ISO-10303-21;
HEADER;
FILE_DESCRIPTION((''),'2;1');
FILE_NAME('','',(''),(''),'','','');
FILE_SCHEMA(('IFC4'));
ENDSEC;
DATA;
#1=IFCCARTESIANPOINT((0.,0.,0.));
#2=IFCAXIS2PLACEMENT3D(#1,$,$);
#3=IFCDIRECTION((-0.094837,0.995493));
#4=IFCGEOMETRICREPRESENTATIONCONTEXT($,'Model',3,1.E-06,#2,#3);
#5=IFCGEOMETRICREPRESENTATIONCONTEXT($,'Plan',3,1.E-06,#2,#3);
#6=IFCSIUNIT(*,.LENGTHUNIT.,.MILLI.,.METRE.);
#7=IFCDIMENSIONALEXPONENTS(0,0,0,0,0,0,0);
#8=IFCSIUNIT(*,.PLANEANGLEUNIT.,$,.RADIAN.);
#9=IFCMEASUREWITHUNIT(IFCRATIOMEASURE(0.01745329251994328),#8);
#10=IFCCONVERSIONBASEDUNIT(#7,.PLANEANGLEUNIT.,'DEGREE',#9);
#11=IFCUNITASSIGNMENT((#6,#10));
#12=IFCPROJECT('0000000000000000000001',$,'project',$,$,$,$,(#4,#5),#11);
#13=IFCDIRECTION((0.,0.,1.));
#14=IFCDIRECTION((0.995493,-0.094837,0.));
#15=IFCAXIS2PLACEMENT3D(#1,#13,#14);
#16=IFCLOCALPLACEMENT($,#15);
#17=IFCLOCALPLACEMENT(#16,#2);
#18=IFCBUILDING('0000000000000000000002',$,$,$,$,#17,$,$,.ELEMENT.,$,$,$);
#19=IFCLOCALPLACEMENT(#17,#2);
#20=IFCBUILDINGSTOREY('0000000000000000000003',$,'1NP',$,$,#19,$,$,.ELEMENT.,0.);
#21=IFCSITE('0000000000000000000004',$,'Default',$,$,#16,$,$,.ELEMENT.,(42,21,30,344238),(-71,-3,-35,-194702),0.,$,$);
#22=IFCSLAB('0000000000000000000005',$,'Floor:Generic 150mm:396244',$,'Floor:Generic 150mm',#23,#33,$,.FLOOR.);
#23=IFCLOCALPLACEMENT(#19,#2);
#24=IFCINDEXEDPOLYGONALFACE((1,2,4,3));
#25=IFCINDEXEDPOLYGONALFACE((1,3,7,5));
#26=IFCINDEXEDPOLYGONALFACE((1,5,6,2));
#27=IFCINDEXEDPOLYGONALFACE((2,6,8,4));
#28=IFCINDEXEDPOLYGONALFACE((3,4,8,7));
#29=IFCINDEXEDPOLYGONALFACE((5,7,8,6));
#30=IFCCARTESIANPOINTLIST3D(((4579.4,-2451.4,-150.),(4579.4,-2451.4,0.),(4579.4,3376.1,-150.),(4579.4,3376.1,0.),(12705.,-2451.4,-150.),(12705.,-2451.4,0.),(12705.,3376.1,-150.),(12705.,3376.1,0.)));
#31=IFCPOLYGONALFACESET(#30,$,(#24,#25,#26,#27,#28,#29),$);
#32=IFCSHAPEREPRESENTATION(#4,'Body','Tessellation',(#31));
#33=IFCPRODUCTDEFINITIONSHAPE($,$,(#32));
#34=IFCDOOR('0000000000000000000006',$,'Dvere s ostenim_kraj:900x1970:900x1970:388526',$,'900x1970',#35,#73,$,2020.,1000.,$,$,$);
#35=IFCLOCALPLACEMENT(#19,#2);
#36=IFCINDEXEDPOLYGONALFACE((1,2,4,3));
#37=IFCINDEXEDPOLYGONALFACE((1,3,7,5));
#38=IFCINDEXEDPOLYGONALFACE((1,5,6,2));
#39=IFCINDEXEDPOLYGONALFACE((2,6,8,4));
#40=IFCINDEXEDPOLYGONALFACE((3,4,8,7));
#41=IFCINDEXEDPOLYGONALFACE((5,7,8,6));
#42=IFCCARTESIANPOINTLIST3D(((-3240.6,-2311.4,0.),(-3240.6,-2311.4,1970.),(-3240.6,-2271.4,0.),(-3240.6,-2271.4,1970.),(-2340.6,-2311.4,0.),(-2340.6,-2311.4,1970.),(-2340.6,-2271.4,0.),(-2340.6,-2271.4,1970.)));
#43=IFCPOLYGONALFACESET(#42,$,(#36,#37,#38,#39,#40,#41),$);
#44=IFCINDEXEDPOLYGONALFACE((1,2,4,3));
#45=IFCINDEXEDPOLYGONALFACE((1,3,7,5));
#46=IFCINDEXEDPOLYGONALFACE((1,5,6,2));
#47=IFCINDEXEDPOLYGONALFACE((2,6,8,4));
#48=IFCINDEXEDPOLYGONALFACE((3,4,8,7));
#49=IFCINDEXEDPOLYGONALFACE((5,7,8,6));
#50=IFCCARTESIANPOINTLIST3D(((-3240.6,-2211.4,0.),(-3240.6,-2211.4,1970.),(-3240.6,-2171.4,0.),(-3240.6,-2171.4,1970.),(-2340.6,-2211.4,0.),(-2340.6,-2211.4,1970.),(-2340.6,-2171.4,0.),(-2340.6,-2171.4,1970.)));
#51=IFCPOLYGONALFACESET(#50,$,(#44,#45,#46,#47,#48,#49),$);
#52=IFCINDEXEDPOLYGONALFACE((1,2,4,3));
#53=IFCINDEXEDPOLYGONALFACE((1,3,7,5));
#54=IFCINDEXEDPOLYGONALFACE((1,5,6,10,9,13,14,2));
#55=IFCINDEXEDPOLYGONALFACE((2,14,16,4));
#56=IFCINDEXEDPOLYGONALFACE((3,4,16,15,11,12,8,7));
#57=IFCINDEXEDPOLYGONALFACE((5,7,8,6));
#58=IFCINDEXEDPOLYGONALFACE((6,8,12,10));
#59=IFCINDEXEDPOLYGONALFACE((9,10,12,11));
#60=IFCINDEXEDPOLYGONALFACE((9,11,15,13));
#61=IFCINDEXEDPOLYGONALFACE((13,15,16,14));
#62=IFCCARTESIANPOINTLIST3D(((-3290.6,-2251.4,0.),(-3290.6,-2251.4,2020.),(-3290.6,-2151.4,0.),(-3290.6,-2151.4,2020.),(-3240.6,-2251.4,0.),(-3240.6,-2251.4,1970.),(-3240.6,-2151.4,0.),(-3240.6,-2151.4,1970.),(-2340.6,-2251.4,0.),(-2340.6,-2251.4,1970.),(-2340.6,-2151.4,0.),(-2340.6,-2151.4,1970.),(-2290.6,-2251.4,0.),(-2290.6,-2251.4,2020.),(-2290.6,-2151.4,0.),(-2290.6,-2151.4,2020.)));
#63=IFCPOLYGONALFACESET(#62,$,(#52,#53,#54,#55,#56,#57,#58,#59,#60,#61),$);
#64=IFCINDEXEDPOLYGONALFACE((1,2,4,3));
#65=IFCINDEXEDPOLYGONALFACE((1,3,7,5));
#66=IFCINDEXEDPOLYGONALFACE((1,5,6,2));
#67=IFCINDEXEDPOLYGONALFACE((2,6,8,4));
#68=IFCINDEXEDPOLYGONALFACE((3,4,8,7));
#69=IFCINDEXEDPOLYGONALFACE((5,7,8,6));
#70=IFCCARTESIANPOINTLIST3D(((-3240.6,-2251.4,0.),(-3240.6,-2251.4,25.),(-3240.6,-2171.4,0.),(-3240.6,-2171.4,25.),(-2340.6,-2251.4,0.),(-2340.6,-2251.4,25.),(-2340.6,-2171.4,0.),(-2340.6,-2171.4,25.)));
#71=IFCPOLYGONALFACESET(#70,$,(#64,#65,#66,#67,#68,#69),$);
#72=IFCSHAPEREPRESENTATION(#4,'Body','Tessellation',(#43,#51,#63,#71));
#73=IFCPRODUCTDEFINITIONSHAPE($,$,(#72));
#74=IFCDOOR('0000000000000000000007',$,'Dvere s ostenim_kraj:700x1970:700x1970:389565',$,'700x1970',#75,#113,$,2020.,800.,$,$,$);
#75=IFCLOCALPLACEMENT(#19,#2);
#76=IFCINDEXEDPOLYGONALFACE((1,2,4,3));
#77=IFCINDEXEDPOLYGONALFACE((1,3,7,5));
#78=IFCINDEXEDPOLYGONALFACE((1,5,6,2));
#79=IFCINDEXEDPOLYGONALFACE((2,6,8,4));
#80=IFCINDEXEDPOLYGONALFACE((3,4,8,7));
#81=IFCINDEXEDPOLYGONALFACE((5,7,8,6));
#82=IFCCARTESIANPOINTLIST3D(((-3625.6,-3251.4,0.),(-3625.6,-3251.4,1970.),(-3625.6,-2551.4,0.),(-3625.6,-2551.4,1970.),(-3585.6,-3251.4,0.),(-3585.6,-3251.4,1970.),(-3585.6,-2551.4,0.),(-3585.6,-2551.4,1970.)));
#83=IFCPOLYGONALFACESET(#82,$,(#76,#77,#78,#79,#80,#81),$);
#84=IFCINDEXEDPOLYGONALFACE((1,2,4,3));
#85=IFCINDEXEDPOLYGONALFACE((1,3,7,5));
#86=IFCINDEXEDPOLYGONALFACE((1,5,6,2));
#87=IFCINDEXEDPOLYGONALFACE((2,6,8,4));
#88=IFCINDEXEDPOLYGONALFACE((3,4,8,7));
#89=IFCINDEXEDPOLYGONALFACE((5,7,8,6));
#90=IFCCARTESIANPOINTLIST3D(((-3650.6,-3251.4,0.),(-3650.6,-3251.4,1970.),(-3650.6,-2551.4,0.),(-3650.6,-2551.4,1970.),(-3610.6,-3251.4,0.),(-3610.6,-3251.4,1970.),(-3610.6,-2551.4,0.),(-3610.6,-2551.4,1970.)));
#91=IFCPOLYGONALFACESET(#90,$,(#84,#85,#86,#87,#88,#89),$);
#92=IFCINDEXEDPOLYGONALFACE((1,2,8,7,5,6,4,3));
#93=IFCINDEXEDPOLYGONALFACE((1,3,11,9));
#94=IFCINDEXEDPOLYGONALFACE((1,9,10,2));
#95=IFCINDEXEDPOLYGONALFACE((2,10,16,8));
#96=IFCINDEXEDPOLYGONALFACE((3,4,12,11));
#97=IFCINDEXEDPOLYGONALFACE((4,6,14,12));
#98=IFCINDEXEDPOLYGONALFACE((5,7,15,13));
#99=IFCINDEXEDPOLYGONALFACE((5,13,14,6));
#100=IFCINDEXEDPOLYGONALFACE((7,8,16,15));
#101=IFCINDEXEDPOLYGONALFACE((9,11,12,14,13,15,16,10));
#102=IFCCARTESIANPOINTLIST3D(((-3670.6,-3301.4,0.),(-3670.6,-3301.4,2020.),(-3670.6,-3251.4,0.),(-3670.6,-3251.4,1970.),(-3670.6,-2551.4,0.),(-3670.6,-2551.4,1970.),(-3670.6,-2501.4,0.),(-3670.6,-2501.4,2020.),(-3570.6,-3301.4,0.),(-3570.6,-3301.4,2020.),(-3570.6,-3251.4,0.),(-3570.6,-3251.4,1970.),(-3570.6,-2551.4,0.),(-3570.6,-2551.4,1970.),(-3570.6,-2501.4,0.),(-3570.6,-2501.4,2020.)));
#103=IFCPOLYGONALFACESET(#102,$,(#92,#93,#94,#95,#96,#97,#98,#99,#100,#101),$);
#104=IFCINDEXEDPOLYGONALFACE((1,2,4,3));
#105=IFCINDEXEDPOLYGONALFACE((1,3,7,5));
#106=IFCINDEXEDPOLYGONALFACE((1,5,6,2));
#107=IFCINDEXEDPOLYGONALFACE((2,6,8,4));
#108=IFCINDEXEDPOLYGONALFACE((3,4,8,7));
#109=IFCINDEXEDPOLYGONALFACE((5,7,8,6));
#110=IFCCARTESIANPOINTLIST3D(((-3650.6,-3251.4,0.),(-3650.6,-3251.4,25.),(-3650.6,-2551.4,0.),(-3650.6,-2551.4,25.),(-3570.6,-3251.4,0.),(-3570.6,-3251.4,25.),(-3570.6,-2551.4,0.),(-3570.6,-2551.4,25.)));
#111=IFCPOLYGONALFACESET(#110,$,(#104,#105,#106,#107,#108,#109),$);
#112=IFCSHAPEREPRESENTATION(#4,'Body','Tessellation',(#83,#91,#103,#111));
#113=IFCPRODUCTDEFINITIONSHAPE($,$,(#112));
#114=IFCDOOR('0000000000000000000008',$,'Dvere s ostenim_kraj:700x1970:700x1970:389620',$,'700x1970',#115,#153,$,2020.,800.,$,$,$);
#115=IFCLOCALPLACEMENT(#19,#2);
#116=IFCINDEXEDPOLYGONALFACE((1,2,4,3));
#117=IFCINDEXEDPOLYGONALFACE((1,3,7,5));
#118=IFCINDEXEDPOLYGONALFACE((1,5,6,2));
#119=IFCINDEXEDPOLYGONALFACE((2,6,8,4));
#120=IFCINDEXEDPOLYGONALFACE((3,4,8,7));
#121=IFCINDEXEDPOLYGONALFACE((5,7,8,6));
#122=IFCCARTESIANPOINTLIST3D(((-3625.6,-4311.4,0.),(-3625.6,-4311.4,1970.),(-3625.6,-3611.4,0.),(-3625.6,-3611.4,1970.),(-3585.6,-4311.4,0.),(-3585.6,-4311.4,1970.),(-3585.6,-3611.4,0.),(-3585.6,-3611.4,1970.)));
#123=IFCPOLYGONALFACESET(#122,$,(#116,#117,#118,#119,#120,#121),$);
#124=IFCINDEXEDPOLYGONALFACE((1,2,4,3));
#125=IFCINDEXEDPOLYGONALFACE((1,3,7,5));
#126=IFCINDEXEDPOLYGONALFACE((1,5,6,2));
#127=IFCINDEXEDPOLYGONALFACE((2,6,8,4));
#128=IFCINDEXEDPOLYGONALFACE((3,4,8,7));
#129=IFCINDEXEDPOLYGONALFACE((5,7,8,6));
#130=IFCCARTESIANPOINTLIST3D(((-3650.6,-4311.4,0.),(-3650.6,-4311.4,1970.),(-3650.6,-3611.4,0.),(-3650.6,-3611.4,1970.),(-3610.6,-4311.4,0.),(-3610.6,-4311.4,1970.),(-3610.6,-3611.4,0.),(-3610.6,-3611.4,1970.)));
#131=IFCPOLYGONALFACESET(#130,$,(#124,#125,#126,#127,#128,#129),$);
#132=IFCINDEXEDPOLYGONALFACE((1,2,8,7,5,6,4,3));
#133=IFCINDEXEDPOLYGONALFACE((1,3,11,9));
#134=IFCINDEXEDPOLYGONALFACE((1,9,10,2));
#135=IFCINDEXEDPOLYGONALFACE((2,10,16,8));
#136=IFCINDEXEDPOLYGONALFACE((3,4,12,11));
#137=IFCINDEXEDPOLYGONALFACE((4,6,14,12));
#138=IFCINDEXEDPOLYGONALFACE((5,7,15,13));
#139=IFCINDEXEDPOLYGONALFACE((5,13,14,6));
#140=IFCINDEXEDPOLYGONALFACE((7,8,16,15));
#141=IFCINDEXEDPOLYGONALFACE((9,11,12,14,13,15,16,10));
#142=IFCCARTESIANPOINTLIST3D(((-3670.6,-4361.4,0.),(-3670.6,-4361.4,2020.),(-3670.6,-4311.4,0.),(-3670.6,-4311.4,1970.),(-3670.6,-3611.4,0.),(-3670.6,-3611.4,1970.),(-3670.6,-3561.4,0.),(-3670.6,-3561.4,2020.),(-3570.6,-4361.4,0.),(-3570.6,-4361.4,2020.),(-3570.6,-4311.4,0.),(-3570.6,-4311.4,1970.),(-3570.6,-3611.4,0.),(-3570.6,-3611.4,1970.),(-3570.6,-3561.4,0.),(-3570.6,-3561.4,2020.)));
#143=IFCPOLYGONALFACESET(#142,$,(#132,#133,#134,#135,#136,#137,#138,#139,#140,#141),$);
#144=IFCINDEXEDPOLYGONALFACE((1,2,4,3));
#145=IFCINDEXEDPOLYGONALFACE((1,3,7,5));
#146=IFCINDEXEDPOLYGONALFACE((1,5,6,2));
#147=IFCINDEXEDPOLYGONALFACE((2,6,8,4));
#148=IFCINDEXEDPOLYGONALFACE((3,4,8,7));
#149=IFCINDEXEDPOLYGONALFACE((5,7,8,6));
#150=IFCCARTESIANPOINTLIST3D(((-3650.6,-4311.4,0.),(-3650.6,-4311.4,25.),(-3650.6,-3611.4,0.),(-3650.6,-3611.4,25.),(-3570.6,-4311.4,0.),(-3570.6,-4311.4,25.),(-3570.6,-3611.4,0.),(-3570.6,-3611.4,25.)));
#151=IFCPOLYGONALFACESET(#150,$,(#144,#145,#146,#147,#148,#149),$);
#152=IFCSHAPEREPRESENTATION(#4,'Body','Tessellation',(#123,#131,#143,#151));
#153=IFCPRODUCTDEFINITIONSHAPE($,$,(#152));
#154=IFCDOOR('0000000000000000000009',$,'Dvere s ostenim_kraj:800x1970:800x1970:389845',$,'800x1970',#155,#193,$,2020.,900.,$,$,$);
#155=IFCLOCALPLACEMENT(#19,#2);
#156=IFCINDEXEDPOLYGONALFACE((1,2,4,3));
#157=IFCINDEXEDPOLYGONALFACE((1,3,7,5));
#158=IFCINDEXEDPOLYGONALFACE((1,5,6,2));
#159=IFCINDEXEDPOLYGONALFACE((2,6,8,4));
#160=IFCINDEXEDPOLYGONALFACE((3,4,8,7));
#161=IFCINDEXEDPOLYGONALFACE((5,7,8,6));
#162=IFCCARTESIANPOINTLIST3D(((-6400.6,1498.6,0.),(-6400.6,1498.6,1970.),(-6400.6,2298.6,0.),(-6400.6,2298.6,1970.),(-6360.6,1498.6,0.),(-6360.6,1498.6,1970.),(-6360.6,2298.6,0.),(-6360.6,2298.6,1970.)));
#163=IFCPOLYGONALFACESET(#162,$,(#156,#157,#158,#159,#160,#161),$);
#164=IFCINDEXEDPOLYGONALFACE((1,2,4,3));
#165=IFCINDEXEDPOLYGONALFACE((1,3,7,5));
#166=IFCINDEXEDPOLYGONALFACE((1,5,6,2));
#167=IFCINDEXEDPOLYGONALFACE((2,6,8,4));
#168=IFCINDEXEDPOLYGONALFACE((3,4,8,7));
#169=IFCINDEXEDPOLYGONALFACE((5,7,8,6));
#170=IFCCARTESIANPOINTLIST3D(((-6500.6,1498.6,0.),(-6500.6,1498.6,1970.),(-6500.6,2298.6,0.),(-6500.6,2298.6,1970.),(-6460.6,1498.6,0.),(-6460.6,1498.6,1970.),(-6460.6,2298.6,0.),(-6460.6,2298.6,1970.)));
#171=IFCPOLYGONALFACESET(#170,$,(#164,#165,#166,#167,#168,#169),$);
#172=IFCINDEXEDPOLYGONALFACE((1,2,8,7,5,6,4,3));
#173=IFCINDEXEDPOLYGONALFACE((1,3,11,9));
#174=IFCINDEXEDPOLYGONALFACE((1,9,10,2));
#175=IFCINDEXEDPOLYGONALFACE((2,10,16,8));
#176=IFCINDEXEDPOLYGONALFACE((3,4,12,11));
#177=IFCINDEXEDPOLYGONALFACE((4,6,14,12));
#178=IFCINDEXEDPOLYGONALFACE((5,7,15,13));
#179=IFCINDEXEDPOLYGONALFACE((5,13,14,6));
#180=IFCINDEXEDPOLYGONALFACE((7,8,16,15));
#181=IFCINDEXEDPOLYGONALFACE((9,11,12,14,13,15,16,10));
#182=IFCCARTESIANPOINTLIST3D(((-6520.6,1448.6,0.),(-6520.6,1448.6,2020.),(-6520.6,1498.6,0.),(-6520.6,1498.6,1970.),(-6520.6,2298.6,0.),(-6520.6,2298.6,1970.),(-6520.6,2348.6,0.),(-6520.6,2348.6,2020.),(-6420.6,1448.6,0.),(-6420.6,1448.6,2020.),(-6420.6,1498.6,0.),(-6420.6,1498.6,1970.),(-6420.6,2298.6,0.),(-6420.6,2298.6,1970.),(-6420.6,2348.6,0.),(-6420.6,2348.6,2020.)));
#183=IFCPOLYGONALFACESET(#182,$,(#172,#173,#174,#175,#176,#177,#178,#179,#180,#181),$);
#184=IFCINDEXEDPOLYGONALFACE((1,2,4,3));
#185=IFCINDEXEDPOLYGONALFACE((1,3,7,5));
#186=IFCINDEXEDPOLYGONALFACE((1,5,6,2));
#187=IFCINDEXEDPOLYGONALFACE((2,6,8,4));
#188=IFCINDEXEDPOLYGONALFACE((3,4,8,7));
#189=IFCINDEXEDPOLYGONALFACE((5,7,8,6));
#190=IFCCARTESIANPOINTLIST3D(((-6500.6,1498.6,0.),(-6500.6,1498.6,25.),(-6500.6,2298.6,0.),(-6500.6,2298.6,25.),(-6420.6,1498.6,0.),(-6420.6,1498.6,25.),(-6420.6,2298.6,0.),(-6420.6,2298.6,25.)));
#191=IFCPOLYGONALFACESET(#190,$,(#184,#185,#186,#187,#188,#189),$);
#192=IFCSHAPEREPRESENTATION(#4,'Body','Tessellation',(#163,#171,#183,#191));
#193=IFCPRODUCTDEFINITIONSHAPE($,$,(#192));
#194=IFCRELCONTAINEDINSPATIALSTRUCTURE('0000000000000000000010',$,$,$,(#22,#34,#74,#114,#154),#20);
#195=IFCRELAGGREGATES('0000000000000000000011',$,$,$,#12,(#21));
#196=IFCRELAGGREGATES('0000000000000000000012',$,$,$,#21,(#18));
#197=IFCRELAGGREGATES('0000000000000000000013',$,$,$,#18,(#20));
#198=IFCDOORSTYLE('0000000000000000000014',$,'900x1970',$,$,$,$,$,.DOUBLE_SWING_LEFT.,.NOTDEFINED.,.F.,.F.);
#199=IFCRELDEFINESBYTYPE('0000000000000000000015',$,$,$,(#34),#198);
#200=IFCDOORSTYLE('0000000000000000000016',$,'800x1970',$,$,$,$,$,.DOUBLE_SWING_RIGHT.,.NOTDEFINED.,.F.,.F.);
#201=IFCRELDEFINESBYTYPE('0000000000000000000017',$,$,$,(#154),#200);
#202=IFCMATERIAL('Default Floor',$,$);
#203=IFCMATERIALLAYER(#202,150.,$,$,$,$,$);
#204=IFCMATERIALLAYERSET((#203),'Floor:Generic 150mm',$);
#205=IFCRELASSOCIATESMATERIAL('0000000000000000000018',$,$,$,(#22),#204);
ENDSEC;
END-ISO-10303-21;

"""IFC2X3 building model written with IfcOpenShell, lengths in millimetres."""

from ifc_helpers import new_model, entity, si_unit, converted_unit, direction, frame, frame_2d, origin, origin_2d_with_axis, place, context, project, spatial, polyline, rectangle, outline, extrude, source, transform, mapped, material, layer, layer_set, layer_usage, type_object, type_shapes, element, save


model = new_model("IFC2X3")

# Units and contexts
model_context = context("Model", 3, precision=1e-06, world=origin(), true_north=direction((-0.094837, 0.995493)))
plan_context = context("Plan", 3, precision=1e-06, world=origin(), true_north=direction((-0.094837, 0.995493)))
ifc_project = project(units=[si_unit("LENGTHUNIT", "METRE", prefix="MILLI"), converted_unit("PLANEANGLEUNIT", "DEGREE", entity("IfcRatioMeasure", 0.01745329251994328), si_unit("PLANEANGLEUNIT", "RADIAN"), dimensions=[0, 0, 0, 0, 0, 0, 0])], contexts=[model_context, plan_context])

# Site, building, storey
site_placement = place(None, frame((0.0, 0.0, 0.0), z_axis=(0.0, 0.0, 1.0), x_axis=(0.995493, -0.094837, 0.0)))
site = spatial("IfcSite", under=ifc_project, at=site_placement, Name="Default", CompositionType="ELEMENT", RefLatitude=(42, 21, 30, 344238), RefLongitude=(-71, -3, -35, -194702), RefElevation=0.0)
building_placement = place(site_placement, origin())
building = spatial("IfcBuilding", under=site, at=building_placement, CompositionType="ELEMENT")
storey_placement = place(building_placement, origin())
storey = spatial("IfcBuildingStorey", under=building, at=storey_placement, Name="1NP", CompositionType="ELEMENT", Elevation=0.0)

# Slab
ifc_material_1 = material(Name="Default Floor")
ifc_layer_1 = layer(ifc_material_1, 150.0)
ifc_layer_set_1 = layer_set([ifc_layer_1], Name="Floor:Generic 150mm")
ifc_layer_usage_1 = layer_usage(ifc_layer_set_1, "AXIS3", "POSITIVE", 0.0)
slab_placement = place(storey_placement, frame((4579.4, -2451.4, -150.0)))
element("IfcSlab", 1, at=slab_placement, inside=storey, material=ifc_layer_usage_1, Name="Floor:Generic 150mm:396244", ObjectType="Floor:Generic 150mm", PredefinedType="FLOOR", context=model_context, shape_type="SweptSolid", body=[
    extrude(rectangle(XDim=5827.5, YDim=8125.7, at=frame_2d((0.0, 0.0), x_axis=(0.0, -1.0))), frame((4062.8, 2913.8, 150.0), z_axis=(0.0, 0.0, -1.0), x_axis=(-1.0, 0.0, 0.0)), (0.0, 0.0, 1.0), 150.0),
])

# Doors
door_style_1 = type_object("IfcDoorStyle", Name="900x1970", ConstructionType="NOTDEFINED", OperationType="DOUBLE_SWING_LEFT", ParameterTakesPrecedence=False, Sizeable=False)
shared_shape_1 = source(origin(), model_context, "Body", "SweptSolid", [
    extrude(rectangle(XDim=900.0, YDim=40.0, at=origin_2d_with_axis()), frame((500.0, 160.0, 0.0), z_axis=(0.0, 0.0, 1.0), x_axis=(-1.0, 0.0, 0.0)), (0.0, 0.0, 1.0), 1970.0),
    extrude(rectangle(XDim=900.0, YDim=40.0, at=origin_2d_with_axis()), frame((500.0, 260.0, 0.0), z_axis=(0.0, 0.0, 1.0), x_axis=(-1.0, 0.0, 0.0)), (0.0, 0.0, 1.0), 1970.0),
    extrude(outline(polyline([(-997.5, -450.0), (-997.5, -500.0), (1022.5, -500.0), (1022.5, 500.0), (-997.5, 500.0), (-997.5, 450.0), (972.5, 450.0), (972.5, -450.0), (-997.5, -450.0)])), frame((500.0, 200.0, 997.5), z_axis=(0.0, -1.0, 0.0), x_axis=(0.0, 0.0, 1.0)), (0.0, 0.0, -1.0), 100.0),
    extrude(rectangle(XDim=900.0, YDim=80.0, at=origin_2d_with_axis()), frame((500.0, 240.0, 0.0), z_axis=(0.0, 0.0, 1.0), x_axis=(-1.0, 0.0, 0.0)), (0.0, 0.0, 1.0), 25.0),
])
type_shapes(door_style_1, [shared_shape_1])
placement_1 = place(storey_placement, frame((-10320.6, -2301.4, 0.0)))
placement_2 = place(placement_1, frame((7030.0, -150.0, 0.0)))
door_1_placement = place(placement_2, origin())
element("IfcDoor", 2, at=door_1_placement, inside=storey, type_object=door_style_1, Name="Dvere s ostenim_kraj:900x1970:900x1970:388526", ObjectType="900x1970", OverallHeight=2020.0, OverallWidth=1000.0, context=model_context, shape_type="MappedRepresentation", body=[
    mapped(shared_shape_1, transform((0.0, 0.0, 0.0), scale=1.0)),
])
shared_shape_2 = source(origin(), model_context, "Body", "SweptSolid", [
    extrude(rectangle(XDim=40.0, YDim=700.0, at=origin_2d_with_axis()), frame((500.0, 85.0, 0.0), z_axis=(0.0, 0.0, 1.0), x_axis=(0.0, -1.0, 0.0)), (0.0, 0.0, 1.0), 1970.0),
    extrude(rectangle(XDim=40.0, YDim=700.0, at=origin_2d_with_axis()), frame((500.0, 110.0, 0.0), z_axis=(0.0, 0.0, 1.0), x_axis=(0.0, -1.0, 0.0)), (0.0, 0.0, 1.0), 1970.0),
    extrude(outline(polyline([(-400.0, -997.5), (-350.0, -997.5), (-350.0, 972.5), (350.0, 972.5), (350.0, -997.5), (400.0, -997.5), (400.0, 1022.5), (-400.0, 1022.5), (-400.0, -997.5)])), frame((500.0, 150.0, 997.5), z_axis=(0.0, -1.0, 0.0), x_axis=(1.0, 0.0, 0.0)), (0.0, 0.0, 1.0), 100.0),
    extrude(rectangle(XDim=80.0, YDim=700.0, at=origin_2d_with_axis()), frame((500.0, 90.0, 0.0), z_axis=(0.0, 0.0, 1.0), x_axis=(0.0, -1.0, 0.0)), (0.0, 0.0, 1.0), 25.0),
])
wall_1_placement = place(storey_placement, frame((-3595.6, -2451.4, 0.0), z_axis=(0.0, 0.0, 1.0), x_axis=(0.0, -1.0, 0.0)))
opening_1_placement = place(wall_1_placement, frame((850.0, 75.0, 0.0)))
door_2_placement = place(opening_1_placement, frame((100.0, 0.0, 0.0), z_axis=(0.0, 0.0, 1.0), x_axis=(-1.0, 0.0, 0.0)))
element("IfcDoor", 3, at=door_2_placement, inside=storey, Name="Dvere s ostenim_kraj:700x1970:700x1970:389565", ObjectType="700x1970", OverallHeight=2020.0, OverallWidth=800.0, context=model_context, shape_type="MappedRepresentation", body=[
    mapped(shared_shape_2, transform((0.0, 0.0, 0.0), scale=1.0)),
])
opening_2_placement = place(wall_1_placement, frame((1910.0, 75.0, 0.0)))
door_3_placement = place(opening_2_placement, frame((100.0, 0.0, 0.0), z_axis=(0.0, 0.0, 1.0), x_axis=(-1.0, 0.0, 0.0)))
element("IfcDoor", 4, at=door_3_placement, inside=storey, Name="Dvere s ostenim_kraj:700x1970:700x1970:389620", ObjectType="700x1970", OverallHeight=2020.0, OverallWidth=800.0, context=model_context, shape_type="MappedRepresentation", body=[
    mapped(shared_shape_2, transform((0.0, 0.0, 0.0), scale=1.0)),
])
door_style_2 = type_object("IfcDoorStyle", Name="800x1970", ConstructionType="NOTDEFINED", OperationType="DOUBLE_SWING_RIGHT", ParameterTakesPrecedence=False, Sizeable=False)
shared_shape_3 = source(origin(), model_context, "Body", "SweptSolid", [
    extrude(rectangle(XDim=40.0, YDim=800.0, at=origin_2d_with_axis()), frame((550.0, 160.0, 0.0), z_axis=(0.0, 0.0, 1.0), x_axis=(0.0, -1.0, 0.0)), (0.0, 0.0, 1.0), 1970.0),
    extrude(rectangle(XDim=40.0, YDim=800.0, at=origin_2d_with_axis()), frame((550.0, 260.0, 0.0), z_axis=(0.0, 0.0, 1.0), x_axis=(0.0, -1.0, 0.0)), (0.0, 0.0, 1.0), 1970.0),
    extrude(outline(polyline([(-450.0, -997.5), (-400.0, -997.5), (-400.0, 972.5), (400.0, 972.5), (400.0, -997.5), (450.0, -997.5), (450.0, 1022.5), (-450.0, 1022.5), (-450.0, -997.5)])), frame((550.0, 300.0, 997.5), z_axis=(0.0, -1.0, 0.0), x_axis=(1.0, 0.0, 0.0)), (0.0, 0.0, 1.0), 100.0),
    extrude(rectangle(XDim=80.0, YDim=800.0, at=origin_2d_with_axis()), frame((550.0, 240.0, 0.0), z_axis=(0.0, 0.0, 1.0), x_axis=(0.0, -1.0, 0.0)), (0.0, 0.0, 1.0), 25.0),
])
type_shapes(door_style_2, [shared_shape_3])
placement_3 = place(storey_placement, frame((-6370.6, -2151.4, 0.0), z_axis=(0.0, 0.0, 1.0), x_axis=(0.0, 1.0, 0.0)))
placement_4 = place(placement_3, frame((3600.0, -150.0, 0.0)))
door_4_placement = place(placement_4, frame((-100.0, 0.0, 0.0)))
element("IfcDoor", 5, at=door_4_placement, inside=storey, type_object=door_style_2, Name="Dvere s ostenim_kraj:800x1970:800x1970:389845", ObjectType="800x1970", OverallHeight=2020.0, OverallWidth=900.0, context=model_context, shape_type="MappedRepresentation", body=[
    mapped(shared_shape_3, transform((0.0, 0.0, 0.0), scale=1.0)),
])

save(model, "model.ifc")
